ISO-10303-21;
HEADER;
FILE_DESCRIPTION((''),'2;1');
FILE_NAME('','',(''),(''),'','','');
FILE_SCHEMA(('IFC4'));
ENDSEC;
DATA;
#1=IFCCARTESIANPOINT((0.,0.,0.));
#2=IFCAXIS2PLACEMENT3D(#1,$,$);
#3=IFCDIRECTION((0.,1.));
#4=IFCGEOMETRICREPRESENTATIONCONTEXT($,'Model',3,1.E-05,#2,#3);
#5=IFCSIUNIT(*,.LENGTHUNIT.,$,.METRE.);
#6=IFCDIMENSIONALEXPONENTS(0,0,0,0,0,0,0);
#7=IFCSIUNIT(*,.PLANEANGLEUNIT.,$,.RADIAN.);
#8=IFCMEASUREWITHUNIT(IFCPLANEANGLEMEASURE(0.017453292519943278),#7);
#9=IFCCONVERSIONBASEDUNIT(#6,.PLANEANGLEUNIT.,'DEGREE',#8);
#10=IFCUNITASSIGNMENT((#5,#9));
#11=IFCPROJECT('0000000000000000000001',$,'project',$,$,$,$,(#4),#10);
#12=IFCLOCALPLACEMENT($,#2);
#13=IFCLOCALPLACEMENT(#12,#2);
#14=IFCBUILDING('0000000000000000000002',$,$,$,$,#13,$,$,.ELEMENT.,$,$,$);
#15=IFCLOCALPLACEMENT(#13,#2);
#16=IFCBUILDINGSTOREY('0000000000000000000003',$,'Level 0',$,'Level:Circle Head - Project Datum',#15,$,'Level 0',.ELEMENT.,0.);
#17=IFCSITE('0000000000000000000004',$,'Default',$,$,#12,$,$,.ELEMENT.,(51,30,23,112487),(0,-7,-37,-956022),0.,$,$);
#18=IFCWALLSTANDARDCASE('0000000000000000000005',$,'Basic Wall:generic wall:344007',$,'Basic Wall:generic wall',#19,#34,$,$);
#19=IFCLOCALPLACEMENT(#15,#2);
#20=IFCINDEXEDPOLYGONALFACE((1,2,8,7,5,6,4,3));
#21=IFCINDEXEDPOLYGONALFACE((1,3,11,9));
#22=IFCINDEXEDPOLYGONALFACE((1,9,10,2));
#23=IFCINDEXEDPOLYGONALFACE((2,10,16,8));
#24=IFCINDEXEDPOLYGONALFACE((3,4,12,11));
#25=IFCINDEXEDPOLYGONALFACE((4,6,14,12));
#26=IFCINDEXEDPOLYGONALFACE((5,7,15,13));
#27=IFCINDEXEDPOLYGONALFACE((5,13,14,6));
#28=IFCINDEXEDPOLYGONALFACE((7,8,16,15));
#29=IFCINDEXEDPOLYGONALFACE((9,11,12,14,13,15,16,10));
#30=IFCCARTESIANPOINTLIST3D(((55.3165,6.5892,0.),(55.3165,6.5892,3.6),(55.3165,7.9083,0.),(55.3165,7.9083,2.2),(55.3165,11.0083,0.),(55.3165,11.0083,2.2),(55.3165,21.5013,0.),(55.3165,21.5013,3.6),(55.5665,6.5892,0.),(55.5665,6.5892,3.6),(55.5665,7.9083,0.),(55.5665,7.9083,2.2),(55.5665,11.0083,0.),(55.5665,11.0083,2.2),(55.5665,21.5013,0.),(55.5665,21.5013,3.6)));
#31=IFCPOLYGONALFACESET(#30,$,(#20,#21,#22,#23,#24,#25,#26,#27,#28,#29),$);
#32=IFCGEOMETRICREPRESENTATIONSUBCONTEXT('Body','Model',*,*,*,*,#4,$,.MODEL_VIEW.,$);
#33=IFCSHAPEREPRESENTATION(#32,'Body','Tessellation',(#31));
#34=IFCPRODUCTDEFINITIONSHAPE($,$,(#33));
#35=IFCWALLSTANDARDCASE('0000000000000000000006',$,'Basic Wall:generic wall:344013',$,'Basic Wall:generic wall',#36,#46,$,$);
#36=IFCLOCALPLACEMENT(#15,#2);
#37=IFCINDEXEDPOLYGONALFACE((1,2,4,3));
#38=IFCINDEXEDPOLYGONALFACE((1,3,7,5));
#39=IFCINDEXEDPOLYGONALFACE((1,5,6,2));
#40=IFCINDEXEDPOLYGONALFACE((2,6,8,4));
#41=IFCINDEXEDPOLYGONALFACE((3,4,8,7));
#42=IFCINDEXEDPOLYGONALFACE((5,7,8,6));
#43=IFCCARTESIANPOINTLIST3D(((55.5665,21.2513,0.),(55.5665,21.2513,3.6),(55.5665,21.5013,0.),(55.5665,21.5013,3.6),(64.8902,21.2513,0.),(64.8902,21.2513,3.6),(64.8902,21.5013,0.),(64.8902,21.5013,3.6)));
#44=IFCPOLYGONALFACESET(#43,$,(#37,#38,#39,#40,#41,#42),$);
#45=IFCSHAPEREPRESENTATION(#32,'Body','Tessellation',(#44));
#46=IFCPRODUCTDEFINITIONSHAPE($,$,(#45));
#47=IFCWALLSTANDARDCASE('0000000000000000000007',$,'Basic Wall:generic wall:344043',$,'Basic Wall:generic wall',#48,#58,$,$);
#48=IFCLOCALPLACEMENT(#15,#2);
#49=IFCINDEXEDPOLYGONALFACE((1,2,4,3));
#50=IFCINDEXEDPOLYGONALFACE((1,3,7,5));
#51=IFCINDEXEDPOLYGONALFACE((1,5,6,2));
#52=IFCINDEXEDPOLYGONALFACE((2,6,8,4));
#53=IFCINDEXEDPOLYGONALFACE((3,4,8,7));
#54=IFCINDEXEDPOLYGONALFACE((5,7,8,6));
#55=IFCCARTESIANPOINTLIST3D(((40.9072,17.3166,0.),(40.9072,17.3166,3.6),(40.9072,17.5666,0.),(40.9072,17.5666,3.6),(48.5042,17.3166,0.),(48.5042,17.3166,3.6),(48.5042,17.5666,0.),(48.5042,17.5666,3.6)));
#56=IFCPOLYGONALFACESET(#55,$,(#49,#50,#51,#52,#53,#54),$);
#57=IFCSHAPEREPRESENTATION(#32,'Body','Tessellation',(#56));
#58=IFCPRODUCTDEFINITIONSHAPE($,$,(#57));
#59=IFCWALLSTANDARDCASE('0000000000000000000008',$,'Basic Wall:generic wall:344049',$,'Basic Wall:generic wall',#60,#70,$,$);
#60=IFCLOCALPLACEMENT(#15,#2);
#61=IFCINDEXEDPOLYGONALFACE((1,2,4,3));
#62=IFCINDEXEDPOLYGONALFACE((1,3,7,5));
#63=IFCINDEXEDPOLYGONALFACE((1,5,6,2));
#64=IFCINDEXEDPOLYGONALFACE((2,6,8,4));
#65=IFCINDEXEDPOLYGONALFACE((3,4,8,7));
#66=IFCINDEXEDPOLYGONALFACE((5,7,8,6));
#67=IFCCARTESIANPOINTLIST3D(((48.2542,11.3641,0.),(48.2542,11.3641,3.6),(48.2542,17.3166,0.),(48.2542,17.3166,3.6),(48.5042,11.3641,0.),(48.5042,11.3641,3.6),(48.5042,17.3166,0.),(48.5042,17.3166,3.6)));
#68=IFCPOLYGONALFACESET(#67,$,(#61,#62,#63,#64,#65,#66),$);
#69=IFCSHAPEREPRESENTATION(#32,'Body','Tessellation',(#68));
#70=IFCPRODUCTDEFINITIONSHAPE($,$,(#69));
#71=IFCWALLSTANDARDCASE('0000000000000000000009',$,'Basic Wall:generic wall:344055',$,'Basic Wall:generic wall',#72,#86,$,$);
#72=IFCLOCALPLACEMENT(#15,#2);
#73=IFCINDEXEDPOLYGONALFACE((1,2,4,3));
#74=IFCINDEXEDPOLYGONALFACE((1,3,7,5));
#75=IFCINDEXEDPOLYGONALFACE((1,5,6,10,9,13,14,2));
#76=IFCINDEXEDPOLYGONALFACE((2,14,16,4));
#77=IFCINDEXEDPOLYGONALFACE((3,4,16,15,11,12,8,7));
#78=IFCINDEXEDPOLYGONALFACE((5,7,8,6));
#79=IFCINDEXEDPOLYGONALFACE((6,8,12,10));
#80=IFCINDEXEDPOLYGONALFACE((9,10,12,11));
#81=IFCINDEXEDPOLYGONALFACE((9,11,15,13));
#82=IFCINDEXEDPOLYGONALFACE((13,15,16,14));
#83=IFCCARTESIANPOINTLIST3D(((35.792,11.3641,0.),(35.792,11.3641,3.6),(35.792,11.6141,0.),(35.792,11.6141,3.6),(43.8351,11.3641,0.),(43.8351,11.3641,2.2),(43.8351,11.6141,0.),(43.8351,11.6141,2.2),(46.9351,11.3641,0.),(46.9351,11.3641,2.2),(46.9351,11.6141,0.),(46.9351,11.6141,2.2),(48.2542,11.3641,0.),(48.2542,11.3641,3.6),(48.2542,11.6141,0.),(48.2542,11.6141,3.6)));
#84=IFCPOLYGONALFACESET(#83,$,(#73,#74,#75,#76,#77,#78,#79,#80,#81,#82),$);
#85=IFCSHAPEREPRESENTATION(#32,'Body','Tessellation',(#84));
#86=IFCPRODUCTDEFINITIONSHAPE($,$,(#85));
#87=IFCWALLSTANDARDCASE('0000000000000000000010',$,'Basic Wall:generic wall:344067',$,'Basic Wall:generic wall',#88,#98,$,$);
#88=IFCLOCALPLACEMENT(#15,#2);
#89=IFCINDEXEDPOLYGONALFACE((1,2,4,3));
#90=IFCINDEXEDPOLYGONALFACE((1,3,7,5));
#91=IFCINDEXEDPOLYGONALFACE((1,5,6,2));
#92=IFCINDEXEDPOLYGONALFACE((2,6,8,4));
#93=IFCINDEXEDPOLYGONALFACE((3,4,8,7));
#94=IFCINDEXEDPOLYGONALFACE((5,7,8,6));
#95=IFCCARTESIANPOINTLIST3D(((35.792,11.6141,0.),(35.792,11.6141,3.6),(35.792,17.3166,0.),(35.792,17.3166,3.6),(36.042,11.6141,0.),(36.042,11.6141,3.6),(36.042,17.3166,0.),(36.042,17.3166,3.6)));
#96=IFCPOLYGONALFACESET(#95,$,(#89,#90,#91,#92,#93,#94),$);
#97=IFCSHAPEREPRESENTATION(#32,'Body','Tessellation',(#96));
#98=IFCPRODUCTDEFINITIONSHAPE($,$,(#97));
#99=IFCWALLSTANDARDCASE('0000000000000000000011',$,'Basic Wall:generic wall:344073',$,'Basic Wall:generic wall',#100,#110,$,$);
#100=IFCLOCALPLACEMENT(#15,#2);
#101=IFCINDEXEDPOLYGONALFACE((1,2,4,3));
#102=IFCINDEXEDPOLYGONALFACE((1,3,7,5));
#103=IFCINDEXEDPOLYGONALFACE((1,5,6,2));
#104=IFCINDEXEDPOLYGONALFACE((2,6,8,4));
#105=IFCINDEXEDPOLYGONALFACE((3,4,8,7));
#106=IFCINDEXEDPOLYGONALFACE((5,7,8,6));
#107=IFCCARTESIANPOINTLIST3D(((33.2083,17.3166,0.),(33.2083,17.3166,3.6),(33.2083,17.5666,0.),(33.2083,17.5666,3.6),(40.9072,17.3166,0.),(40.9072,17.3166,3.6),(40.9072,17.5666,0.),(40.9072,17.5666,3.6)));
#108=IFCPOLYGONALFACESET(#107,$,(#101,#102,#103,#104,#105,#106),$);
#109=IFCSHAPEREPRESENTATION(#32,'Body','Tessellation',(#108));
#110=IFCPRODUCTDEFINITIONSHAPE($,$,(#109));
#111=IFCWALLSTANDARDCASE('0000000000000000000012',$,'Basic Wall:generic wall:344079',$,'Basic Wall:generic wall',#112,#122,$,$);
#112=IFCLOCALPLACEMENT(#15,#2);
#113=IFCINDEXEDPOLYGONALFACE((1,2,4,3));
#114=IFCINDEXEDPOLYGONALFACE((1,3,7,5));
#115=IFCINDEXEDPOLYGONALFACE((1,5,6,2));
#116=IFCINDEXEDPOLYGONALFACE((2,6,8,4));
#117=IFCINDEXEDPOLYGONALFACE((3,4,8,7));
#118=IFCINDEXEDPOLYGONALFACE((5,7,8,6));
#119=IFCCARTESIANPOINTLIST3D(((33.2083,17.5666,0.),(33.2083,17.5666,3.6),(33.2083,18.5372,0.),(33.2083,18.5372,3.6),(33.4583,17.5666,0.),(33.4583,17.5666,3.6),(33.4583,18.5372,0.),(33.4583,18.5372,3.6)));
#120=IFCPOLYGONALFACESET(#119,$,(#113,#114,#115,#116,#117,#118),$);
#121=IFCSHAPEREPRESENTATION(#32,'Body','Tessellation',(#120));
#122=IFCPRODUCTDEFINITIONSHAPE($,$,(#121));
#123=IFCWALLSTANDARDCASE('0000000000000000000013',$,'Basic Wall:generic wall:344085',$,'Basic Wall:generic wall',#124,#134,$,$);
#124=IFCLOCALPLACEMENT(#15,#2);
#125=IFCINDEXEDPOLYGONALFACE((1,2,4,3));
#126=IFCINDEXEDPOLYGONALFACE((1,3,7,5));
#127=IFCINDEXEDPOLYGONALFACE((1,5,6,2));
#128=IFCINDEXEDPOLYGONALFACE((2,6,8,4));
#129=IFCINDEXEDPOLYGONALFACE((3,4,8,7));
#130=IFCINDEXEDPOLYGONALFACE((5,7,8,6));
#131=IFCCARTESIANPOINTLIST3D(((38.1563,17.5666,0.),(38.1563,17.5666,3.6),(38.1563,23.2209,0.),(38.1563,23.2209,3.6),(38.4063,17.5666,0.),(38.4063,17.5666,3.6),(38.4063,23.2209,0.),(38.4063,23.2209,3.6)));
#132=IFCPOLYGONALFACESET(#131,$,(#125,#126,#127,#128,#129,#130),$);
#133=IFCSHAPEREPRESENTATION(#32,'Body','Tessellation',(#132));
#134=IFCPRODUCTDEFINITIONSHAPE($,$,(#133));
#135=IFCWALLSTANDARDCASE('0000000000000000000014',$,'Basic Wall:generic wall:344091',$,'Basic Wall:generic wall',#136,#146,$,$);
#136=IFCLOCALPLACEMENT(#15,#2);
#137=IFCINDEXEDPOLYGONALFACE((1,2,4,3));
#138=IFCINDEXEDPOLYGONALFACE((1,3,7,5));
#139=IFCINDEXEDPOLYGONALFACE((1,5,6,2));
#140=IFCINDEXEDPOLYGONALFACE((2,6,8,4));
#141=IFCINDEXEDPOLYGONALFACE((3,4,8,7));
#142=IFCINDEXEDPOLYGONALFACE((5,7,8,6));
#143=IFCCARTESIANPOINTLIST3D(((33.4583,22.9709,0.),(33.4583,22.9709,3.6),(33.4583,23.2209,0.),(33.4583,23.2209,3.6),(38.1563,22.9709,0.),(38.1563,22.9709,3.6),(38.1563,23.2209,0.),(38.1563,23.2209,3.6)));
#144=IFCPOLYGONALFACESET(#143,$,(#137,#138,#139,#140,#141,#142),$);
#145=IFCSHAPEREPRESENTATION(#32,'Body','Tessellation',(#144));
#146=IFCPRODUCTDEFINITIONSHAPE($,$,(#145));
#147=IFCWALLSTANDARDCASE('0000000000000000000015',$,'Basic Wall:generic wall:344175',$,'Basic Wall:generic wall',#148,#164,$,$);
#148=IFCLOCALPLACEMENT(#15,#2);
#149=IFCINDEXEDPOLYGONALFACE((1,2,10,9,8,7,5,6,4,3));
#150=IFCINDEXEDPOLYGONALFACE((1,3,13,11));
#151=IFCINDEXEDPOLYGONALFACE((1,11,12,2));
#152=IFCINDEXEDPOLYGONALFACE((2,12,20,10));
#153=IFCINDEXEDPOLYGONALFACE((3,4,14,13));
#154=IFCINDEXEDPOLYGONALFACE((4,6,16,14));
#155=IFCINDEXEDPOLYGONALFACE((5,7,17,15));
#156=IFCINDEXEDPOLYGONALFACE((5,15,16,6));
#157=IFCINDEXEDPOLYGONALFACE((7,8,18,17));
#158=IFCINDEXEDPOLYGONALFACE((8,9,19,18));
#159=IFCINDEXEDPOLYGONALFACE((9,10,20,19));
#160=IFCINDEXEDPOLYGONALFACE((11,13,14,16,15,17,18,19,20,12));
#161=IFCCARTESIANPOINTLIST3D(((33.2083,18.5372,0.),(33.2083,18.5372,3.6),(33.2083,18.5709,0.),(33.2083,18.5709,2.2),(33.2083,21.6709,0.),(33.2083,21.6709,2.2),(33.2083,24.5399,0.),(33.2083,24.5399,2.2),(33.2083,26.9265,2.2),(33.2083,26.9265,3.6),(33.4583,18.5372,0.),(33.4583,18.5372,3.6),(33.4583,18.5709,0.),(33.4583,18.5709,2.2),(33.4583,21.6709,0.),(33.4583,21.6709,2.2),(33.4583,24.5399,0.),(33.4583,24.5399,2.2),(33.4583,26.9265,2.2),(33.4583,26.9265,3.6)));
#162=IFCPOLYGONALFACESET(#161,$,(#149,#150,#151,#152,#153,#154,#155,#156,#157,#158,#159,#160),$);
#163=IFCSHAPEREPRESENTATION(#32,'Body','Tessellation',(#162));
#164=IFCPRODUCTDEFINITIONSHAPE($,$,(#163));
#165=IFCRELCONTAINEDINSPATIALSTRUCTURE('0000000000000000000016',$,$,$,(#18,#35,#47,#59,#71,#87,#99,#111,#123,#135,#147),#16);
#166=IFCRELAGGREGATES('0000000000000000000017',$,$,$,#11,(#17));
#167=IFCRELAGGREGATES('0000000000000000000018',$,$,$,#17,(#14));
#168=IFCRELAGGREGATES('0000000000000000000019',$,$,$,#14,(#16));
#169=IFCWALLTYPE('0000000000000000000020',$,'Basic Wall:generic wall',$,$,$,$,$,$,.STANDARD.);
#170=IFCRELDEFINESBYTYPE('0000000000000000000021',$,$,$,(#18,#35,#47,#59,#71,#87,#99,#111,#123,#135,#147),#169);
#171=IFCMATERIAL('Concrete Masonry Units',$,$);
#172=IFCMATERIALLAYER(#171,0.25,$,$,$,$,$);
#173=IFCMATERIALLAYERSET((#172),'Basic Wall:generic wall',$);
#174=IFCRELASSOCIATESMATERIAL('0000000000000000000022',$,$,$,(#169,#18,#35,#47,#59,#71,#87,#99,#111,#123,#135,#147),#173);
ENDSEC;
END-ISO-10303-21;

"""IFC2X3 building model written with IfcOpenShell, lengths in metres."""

from ifc_helpers import new_model, entity, si_unit, converted_unit, direction, frame, frame_2d, origin, place, context, subcontext, project, spatial, rectangle, extrude, material, layer, layer_set, layer_usage, type_object, element, save


model = new_model("IFC2X3")

# Units and contexts
model_context = context("Model", 3, precision=1e-05, world=origin(), true_north=direction((0.0, 1.0)))
body_context = subcontext(model_context, "Body", "Model", "MODEL_VIEW")
ifc_project = project(units=[si_unit("LENGTHUNIT", "METRE"), converted_unit("PLANEANGLEUNIT", "DEGREE", entity("IfcPlaneAngleMeasure", 0.017453292519943278), si_unit("PLANEANGLEUNIT", "RADIAN"), dimensions=[0, 0, 0, 0, 0, 0, 0])], contexts=[model_context])

# Site, building, storey
site_placement = place(None, origin())
site = spatial("IfcSite", under=ifc_project, at=site_placement, Name="Default", CompositionType="ELEMENT", RefLatitude=(51, 30, 23, 112487), RefLongitude=(0, -7, -37, -956022), RefElevation=0.0)
building_placement = place(site_placement, origin())
building = spatial("IfcBuilding", under=site, at=building_placement, CompositionType="ELEMENT")
storey_placement = place(building_placement, origin())
storey = spatial("IfcBuildingStorey", under=building, at=storey_placement, Name="Level 0", ObjectType="Level:Circle Head - Project Datum", LongName="Level 0", CompositionType="ELEMENT", Elevation=0.0)

# Shared definitions
ifc_material = material(Name="Concrete Masonry Units")
ifc_layer = layer(ifc_material, 0.25)
ifc_layer_set = layer_set([ifc_layer], Name="Basic Wall:generic wall")
wall_type = type_object("IfcWallType", Name="Basic Wall:generic wall", PredefinedType="STANDARD", material=ifc_layer_set)

# Wall, opening
ifc_layer_usage_1 = layer_usage(ifc_layer_set, "AXIS2", "NEGATIVE", 0.125)
wall_1_placement = place(storey_placement, frame((55.4415, 21.5013, 0.0), z_axis=(0.0, 0.0, 1.0), x_axis=(0.0, -1.0, 0.0)))
wall_1 = element("IfcWallStandardCase", 1, at=wall_1_placement, inside=storey, type_object=wall_type, material=ifc_layer_usage_1, Name="Basic Wall:generic wall:344007", ObjectType="Basic Wall:generic wall", context=body_context, shape_type="SweptSolid", body=[
    extrude(rectangle(XDim=14.9121, YDim=0.25, at=frame_2d((7.4561, 0.0), x_axis=(1.0, 0.0))), origin(), (0.0, 0.0, 1.0), 3.6),
])
opening_1_placement = place(wall_1_placement, frame((10.4931, -0.125, 0.0)))
element("IfcOpeningElement", 2, at=opening_1_placement, cuts=wall_1, ObjectType="Opening", context=body_context, shape_type="SweptSolid", body=[
    extrude(rectangle(XDim=2.2, YDim=3.1, at=frame_2d((1.1, 1.55), x_axis=(1.0, 0.0))), frame((0.0, 0.0, 0.0), z_axis=(0.0, 1.0, 0.0), x_axis=(0.0, 0.0, 1.0)), (0.0, 0.0, 1.0), 0.25),
])

# Walls
ifc_layer_usage_2 = layer_usage(ifc_layer_set, "AXIS2", "NEGATIVE", 0.125)
wall_2_placement = place(storey_placement, frame((64.8902, 21.3763, 0.0), z_axis=(0.0, 0.0, 1.0), x_axis=(-1.0, 0.0, 0.0)))
element("IfcWallStandardCase", 3, at=wall_2_placement, inside=storey, type_object=wall_type, material=ifc_layer_usage_2, Name="Basic Wall:generic wall:344013", ObjectType="Basic Wall:generic wall", context=body_context, shape_type="SweptSolid", body=[
    extrude(rectangle(XDim=9.3237, YDim=0.25, at=frame_2d((4.6618, 0.0), x_axis=(-1.0, 0.0))), origin(), (0.0, 0.0, 1.0), 3.6),
])
ifc_layer_usage_3 = layer_usage(ifc_layer_set, "AXIS2", "NEGATIVE", 0.125)
wall_3_placement = place(storey_placement, frame((40.9072, 17.4416, 0.0)))
element("IfcWallStandardCase", 4, at=wall_3_placement, inside=storey, type_object=wall_type, material=ifc_layer_usage_3, Name="Basic Wall:generic wall:344043", ObjectType="Basic Wall:generic wall", context=body_context, shape_type="SweptSolid", body=[
    extrude(rectangle(XDim=7.597, YDim=0.25, at=frame_2d((3.7985, 0.0), x_axis=(-1.0, 0.0))), origin(), (0.0, 0.0, 1.0), 3.6),
])
ifc_layer_usage_4 = layer_usage(ifc_layer_set, "AXIS2", "NEGATIVE", 0.125)
wall_4_placement = place(storey_placement, frame((48.3792, 17.3166, 0.0), z_axis=(0.0, 0.0, 1.0), x_axis=(0.0, -1.0, 0.0)))
element("IfcWallStandardCase", 5, at=wall_4_placement, inside=storey, type_object=wall_type, material=ifc_layer_usage_4, Name="Basic Wall:generic wall:344049", ObjectType="Basic Wall:generic wall", context=body_context, shape_type="SweptSolid", body=[
    extrude(rectangle(XDim=5.9526, YDim=0.25, at=frame_2d((2.9763, 0.0), x_axis=(-1.0, 0.0))), origin(), (0.0, 0.0, 1.0), 3.6),
])

# Wall, opening
ifc_layer_usage_5 = layer_usage(ifc_layer_set, "AXIS2", "NEGATIVE", 0.125)
wall_5_placement = place(storey_placement, frame((48.2542, 11.4891, 0.0), z_axis=(0.0, 0.0, 1.0), x_axis=(-1.0, 0.0, 0.0)))
wall_5 = element("IfcWallStandardCase", 6, at=wall_5_placement, inside=storey, type_object=wall_type, material=ifc_layer_usage_5, Name="Basic Wall:generic wall:344055", ObjectType="Basic Wall:generic wall", context=body_context, shape_type="SweptSolid", body=[
    extrude(rectangle(XDim=12.4622, YDim=0.25, at=frame_2d((6.2311, 0.0), x_axis=(-1.0, 0.0))), origin(), (0.0, 0.0, 1.0), 3.6),
])
opening_2_placement = place(wall_5_placement, frame((4.419, 0.125, 0.0)))
element("IfcOpeningElement", 7, at=opening_2_placement, cuts=wall_5, ObjectType="Opening", context=body_context, shape_type="SweptSolid", body=[
    extrude(rectangle(XDim=2.2, YDim=3.1, at=frame_2d((1.1, 1.55), x_axis=(1.0, 0.0))), frame((0.0, 0.0, 0.0), z_axis=(0.0, -1.0, 0.0), x_axis=(0.0, 0.0, 1.0)), (0.0, 0.0, 1.0), 0.25),
])

# Walls
ifc_layer_usage_6 = layer_usage(ifc_layer_set, "AXIS2", "NEGATIVE", 0.125)
wall_6_placement = place(storey_placement, frame((35.917, 11.6141, 0.0), z_axis=(0.0, 0.0, 1.0), x_axis=(0.0, 1.0, 0.0)))
element("IfcWallStandardCase", 8, at=wall_6_placement, inside=storey, type_object=wall_type, material=ifc_layer_usage_6, Name="Basic Wall:generic wall:344067", ObjectType="Basic Wall:generic wall", context=body_context, shape_type="SweptSolid", body=[
    extrude(rectangle(XDim=5.7026, YDim=0.25, at=frame_2d((2.8513, 0.0), x_axis=(-1.0, 0.0))), origin(), (0.0, 0.0, 1.0), 3.6),
])
ifc_layer_usage_7 = layer_usage(ifc_layer_set, "AXIS2", "NEGATIVE", 0.125)
wall_7_placement = place(storey_placement, frame((33.2083, 17.4416, 0.0)))
element("IfcWallStandardCase", 9, at=wall_7_placement, inside=storey, type_object=wall_type, material=ifc_layer_usage_7, Name="Basic Wall:generic wall:344073", ObjectType="Basic Wall:generic wall", context=body_context, shape_type="SweptSolid", body=[
    extrude(rectangle(XDim=7.6989, YDim=0.25, at=frame_2d((3.8494, 0.0), x_axis=(-1.0, 0.0))), origin(), (0.0, 0.0, 1.0), 3.6),
])
ifc_layer_usage_8 = layer_usage(ifc_layer_set, "AXIS2", "NEGATIVE", 0.125)
wall_8_placement = place(storey_placement, frame((33.3333, 18.5372, 0.0), z_axis=(0.0, 0.0, 1.0), x_axis=(0.0, -1.0, 0.0)))
element("IfcWallStandardCase", 10, at=wall_8_placement, inside=storey, type_object=wall_type, material=ifc_layer_usage_8, Name="Basic Wall:generic wall:344079", ObjectType="Basic Wall:generic wall", context=body_context, shape_type="SweptSolid", body=[
    extrude(rectangle(XDim=0.9706, YDim=0.25, at=frame_2d((0.4853, 0.0), x_axis=(-1.0, 0.0))), origin(), (0.0, 0.0, 1.0), 3.6),
])
ifc_layer_usage_9 = layer_usage(ifc_layer_set, "AXIS2", "NEGATIVE", 0.125)
wall_9_placement = place(storey_placement, frame((38.2813, 17.5666, 0.0), z_axis=(0.0, 0.0, 1.0), x_axis=(0.0, 1.0, 0.0)))
element("IfcWallStandardCase", 11, at=wall_9_placement, inside=storey, type_object=wall_type, material=ifc_layer_usage_9, Name="Basic Wall:generic wall:344085", ObjectType="Basic Wall:generic wall", context=body_context, shape_type="SweptSolid", body=[
    extrude(rectangle(XDim=5.6542, YDim=0.25, at=frame_2d((2.8271, 0.0), x_axis=(-1.0, 0.0))), origin(), (0.0, 0.0, 1.0), 3.6),
])
ifc_layer_usage_10 = layer_usage(ifc_layer_set, "AXIS2", "NEGATIVE", 0.125)
wall_10_placement = place(storey_placement, frame((33.4583, 23.0959, 0.0)))
element("IfcWallStandardCase", 12, at=wall_10_placement, inside=storey, type_object=wall_type, material=ifc_layer_usage_10, Name="Basic Wall:generic wall:344091", ObjectType="Basic Wall:generic wall", context=body_context, shape_type="SweptSolid", body=[
    extrude(rectangle(XDim=4.698, YDim=0.25, at=frame_2d((2.349, 0.0), x_axis=(-1.0, 0.0))), origin(), (0.0, 0.0, 1.0), 3.6),
])

# Wall, openings
ifc_layer_usage_11 = layer_usage(ifc_layer_set, "AXIS2", "NEGATIVE", 0.125)
wall_11_placement = place(storey_placement, frame((33.3333, 18.5372, 0.0), z_axis=(0.0, 0.0, 1.0), x_axis=(0.0, 1.0, 0.0)))
wall_11 = element("IfcWallStandardCase", 13, at=wall_11_placement, inside=storey, type_object=wall_type, material=ifc_layer_usage_11, Name="Basic Wall:generic wall:344175", ObjectType="Basic Wall:generic wall", context=body_context, shape_type="SweptSolid", body=[
    extrude(rectangle(XDim=8.3893, YDim=0.25, at=frame_2d((4.1946, 0.0), x_axis=(-1.0, 0.0))), origin(), (0.0, 0.0, 1.0), 3.6),
])
opening_3_placement = place(wall_11_placement, frame((3.1337, 0.125, 0.0)))
element("IfcOpeningElement", 14, at=opening_3_placement, cuts=wall_11, ObjectType="Opening", context=body_context, shape_type="SweptSolid", body=[
    extrude(rectangle(XDim=2.2, YDim=3.1, at=frame_2d((1.1, 1.55), x_axis=(1.0, 0.0))), frame((0.0, 0.0, 0.0), z_axis=(0.0, -1.0, 0.0), x_axis=(0.0, 0.0, 1.0)), (0.0, 0.0, 1.0), 0.25),
])
opening_4_placement = place(wall_11_placement, frame((9.1027, 0.125, 0.0)))
element("IfcOpeningElement", 15, at=opening_4_placement, cuts=wall_11, ObjectType="Opening", context=body_context, shape_type="SweptSolid", body=[
    extrude(rectangle(XDim=2.2, YDim=3.1, at=frame_2d((1.1, 1.55), x_axis=(1.0, 0.0))), frame((0.0, 0.0, 0.0), z_axis=(0.0, -1.0, 0.0), x_axis=(0.0, 0.0, 1.0)), (0.0, 0.0, 1.0), 0.25),
])

save(model, "model.ifc")
